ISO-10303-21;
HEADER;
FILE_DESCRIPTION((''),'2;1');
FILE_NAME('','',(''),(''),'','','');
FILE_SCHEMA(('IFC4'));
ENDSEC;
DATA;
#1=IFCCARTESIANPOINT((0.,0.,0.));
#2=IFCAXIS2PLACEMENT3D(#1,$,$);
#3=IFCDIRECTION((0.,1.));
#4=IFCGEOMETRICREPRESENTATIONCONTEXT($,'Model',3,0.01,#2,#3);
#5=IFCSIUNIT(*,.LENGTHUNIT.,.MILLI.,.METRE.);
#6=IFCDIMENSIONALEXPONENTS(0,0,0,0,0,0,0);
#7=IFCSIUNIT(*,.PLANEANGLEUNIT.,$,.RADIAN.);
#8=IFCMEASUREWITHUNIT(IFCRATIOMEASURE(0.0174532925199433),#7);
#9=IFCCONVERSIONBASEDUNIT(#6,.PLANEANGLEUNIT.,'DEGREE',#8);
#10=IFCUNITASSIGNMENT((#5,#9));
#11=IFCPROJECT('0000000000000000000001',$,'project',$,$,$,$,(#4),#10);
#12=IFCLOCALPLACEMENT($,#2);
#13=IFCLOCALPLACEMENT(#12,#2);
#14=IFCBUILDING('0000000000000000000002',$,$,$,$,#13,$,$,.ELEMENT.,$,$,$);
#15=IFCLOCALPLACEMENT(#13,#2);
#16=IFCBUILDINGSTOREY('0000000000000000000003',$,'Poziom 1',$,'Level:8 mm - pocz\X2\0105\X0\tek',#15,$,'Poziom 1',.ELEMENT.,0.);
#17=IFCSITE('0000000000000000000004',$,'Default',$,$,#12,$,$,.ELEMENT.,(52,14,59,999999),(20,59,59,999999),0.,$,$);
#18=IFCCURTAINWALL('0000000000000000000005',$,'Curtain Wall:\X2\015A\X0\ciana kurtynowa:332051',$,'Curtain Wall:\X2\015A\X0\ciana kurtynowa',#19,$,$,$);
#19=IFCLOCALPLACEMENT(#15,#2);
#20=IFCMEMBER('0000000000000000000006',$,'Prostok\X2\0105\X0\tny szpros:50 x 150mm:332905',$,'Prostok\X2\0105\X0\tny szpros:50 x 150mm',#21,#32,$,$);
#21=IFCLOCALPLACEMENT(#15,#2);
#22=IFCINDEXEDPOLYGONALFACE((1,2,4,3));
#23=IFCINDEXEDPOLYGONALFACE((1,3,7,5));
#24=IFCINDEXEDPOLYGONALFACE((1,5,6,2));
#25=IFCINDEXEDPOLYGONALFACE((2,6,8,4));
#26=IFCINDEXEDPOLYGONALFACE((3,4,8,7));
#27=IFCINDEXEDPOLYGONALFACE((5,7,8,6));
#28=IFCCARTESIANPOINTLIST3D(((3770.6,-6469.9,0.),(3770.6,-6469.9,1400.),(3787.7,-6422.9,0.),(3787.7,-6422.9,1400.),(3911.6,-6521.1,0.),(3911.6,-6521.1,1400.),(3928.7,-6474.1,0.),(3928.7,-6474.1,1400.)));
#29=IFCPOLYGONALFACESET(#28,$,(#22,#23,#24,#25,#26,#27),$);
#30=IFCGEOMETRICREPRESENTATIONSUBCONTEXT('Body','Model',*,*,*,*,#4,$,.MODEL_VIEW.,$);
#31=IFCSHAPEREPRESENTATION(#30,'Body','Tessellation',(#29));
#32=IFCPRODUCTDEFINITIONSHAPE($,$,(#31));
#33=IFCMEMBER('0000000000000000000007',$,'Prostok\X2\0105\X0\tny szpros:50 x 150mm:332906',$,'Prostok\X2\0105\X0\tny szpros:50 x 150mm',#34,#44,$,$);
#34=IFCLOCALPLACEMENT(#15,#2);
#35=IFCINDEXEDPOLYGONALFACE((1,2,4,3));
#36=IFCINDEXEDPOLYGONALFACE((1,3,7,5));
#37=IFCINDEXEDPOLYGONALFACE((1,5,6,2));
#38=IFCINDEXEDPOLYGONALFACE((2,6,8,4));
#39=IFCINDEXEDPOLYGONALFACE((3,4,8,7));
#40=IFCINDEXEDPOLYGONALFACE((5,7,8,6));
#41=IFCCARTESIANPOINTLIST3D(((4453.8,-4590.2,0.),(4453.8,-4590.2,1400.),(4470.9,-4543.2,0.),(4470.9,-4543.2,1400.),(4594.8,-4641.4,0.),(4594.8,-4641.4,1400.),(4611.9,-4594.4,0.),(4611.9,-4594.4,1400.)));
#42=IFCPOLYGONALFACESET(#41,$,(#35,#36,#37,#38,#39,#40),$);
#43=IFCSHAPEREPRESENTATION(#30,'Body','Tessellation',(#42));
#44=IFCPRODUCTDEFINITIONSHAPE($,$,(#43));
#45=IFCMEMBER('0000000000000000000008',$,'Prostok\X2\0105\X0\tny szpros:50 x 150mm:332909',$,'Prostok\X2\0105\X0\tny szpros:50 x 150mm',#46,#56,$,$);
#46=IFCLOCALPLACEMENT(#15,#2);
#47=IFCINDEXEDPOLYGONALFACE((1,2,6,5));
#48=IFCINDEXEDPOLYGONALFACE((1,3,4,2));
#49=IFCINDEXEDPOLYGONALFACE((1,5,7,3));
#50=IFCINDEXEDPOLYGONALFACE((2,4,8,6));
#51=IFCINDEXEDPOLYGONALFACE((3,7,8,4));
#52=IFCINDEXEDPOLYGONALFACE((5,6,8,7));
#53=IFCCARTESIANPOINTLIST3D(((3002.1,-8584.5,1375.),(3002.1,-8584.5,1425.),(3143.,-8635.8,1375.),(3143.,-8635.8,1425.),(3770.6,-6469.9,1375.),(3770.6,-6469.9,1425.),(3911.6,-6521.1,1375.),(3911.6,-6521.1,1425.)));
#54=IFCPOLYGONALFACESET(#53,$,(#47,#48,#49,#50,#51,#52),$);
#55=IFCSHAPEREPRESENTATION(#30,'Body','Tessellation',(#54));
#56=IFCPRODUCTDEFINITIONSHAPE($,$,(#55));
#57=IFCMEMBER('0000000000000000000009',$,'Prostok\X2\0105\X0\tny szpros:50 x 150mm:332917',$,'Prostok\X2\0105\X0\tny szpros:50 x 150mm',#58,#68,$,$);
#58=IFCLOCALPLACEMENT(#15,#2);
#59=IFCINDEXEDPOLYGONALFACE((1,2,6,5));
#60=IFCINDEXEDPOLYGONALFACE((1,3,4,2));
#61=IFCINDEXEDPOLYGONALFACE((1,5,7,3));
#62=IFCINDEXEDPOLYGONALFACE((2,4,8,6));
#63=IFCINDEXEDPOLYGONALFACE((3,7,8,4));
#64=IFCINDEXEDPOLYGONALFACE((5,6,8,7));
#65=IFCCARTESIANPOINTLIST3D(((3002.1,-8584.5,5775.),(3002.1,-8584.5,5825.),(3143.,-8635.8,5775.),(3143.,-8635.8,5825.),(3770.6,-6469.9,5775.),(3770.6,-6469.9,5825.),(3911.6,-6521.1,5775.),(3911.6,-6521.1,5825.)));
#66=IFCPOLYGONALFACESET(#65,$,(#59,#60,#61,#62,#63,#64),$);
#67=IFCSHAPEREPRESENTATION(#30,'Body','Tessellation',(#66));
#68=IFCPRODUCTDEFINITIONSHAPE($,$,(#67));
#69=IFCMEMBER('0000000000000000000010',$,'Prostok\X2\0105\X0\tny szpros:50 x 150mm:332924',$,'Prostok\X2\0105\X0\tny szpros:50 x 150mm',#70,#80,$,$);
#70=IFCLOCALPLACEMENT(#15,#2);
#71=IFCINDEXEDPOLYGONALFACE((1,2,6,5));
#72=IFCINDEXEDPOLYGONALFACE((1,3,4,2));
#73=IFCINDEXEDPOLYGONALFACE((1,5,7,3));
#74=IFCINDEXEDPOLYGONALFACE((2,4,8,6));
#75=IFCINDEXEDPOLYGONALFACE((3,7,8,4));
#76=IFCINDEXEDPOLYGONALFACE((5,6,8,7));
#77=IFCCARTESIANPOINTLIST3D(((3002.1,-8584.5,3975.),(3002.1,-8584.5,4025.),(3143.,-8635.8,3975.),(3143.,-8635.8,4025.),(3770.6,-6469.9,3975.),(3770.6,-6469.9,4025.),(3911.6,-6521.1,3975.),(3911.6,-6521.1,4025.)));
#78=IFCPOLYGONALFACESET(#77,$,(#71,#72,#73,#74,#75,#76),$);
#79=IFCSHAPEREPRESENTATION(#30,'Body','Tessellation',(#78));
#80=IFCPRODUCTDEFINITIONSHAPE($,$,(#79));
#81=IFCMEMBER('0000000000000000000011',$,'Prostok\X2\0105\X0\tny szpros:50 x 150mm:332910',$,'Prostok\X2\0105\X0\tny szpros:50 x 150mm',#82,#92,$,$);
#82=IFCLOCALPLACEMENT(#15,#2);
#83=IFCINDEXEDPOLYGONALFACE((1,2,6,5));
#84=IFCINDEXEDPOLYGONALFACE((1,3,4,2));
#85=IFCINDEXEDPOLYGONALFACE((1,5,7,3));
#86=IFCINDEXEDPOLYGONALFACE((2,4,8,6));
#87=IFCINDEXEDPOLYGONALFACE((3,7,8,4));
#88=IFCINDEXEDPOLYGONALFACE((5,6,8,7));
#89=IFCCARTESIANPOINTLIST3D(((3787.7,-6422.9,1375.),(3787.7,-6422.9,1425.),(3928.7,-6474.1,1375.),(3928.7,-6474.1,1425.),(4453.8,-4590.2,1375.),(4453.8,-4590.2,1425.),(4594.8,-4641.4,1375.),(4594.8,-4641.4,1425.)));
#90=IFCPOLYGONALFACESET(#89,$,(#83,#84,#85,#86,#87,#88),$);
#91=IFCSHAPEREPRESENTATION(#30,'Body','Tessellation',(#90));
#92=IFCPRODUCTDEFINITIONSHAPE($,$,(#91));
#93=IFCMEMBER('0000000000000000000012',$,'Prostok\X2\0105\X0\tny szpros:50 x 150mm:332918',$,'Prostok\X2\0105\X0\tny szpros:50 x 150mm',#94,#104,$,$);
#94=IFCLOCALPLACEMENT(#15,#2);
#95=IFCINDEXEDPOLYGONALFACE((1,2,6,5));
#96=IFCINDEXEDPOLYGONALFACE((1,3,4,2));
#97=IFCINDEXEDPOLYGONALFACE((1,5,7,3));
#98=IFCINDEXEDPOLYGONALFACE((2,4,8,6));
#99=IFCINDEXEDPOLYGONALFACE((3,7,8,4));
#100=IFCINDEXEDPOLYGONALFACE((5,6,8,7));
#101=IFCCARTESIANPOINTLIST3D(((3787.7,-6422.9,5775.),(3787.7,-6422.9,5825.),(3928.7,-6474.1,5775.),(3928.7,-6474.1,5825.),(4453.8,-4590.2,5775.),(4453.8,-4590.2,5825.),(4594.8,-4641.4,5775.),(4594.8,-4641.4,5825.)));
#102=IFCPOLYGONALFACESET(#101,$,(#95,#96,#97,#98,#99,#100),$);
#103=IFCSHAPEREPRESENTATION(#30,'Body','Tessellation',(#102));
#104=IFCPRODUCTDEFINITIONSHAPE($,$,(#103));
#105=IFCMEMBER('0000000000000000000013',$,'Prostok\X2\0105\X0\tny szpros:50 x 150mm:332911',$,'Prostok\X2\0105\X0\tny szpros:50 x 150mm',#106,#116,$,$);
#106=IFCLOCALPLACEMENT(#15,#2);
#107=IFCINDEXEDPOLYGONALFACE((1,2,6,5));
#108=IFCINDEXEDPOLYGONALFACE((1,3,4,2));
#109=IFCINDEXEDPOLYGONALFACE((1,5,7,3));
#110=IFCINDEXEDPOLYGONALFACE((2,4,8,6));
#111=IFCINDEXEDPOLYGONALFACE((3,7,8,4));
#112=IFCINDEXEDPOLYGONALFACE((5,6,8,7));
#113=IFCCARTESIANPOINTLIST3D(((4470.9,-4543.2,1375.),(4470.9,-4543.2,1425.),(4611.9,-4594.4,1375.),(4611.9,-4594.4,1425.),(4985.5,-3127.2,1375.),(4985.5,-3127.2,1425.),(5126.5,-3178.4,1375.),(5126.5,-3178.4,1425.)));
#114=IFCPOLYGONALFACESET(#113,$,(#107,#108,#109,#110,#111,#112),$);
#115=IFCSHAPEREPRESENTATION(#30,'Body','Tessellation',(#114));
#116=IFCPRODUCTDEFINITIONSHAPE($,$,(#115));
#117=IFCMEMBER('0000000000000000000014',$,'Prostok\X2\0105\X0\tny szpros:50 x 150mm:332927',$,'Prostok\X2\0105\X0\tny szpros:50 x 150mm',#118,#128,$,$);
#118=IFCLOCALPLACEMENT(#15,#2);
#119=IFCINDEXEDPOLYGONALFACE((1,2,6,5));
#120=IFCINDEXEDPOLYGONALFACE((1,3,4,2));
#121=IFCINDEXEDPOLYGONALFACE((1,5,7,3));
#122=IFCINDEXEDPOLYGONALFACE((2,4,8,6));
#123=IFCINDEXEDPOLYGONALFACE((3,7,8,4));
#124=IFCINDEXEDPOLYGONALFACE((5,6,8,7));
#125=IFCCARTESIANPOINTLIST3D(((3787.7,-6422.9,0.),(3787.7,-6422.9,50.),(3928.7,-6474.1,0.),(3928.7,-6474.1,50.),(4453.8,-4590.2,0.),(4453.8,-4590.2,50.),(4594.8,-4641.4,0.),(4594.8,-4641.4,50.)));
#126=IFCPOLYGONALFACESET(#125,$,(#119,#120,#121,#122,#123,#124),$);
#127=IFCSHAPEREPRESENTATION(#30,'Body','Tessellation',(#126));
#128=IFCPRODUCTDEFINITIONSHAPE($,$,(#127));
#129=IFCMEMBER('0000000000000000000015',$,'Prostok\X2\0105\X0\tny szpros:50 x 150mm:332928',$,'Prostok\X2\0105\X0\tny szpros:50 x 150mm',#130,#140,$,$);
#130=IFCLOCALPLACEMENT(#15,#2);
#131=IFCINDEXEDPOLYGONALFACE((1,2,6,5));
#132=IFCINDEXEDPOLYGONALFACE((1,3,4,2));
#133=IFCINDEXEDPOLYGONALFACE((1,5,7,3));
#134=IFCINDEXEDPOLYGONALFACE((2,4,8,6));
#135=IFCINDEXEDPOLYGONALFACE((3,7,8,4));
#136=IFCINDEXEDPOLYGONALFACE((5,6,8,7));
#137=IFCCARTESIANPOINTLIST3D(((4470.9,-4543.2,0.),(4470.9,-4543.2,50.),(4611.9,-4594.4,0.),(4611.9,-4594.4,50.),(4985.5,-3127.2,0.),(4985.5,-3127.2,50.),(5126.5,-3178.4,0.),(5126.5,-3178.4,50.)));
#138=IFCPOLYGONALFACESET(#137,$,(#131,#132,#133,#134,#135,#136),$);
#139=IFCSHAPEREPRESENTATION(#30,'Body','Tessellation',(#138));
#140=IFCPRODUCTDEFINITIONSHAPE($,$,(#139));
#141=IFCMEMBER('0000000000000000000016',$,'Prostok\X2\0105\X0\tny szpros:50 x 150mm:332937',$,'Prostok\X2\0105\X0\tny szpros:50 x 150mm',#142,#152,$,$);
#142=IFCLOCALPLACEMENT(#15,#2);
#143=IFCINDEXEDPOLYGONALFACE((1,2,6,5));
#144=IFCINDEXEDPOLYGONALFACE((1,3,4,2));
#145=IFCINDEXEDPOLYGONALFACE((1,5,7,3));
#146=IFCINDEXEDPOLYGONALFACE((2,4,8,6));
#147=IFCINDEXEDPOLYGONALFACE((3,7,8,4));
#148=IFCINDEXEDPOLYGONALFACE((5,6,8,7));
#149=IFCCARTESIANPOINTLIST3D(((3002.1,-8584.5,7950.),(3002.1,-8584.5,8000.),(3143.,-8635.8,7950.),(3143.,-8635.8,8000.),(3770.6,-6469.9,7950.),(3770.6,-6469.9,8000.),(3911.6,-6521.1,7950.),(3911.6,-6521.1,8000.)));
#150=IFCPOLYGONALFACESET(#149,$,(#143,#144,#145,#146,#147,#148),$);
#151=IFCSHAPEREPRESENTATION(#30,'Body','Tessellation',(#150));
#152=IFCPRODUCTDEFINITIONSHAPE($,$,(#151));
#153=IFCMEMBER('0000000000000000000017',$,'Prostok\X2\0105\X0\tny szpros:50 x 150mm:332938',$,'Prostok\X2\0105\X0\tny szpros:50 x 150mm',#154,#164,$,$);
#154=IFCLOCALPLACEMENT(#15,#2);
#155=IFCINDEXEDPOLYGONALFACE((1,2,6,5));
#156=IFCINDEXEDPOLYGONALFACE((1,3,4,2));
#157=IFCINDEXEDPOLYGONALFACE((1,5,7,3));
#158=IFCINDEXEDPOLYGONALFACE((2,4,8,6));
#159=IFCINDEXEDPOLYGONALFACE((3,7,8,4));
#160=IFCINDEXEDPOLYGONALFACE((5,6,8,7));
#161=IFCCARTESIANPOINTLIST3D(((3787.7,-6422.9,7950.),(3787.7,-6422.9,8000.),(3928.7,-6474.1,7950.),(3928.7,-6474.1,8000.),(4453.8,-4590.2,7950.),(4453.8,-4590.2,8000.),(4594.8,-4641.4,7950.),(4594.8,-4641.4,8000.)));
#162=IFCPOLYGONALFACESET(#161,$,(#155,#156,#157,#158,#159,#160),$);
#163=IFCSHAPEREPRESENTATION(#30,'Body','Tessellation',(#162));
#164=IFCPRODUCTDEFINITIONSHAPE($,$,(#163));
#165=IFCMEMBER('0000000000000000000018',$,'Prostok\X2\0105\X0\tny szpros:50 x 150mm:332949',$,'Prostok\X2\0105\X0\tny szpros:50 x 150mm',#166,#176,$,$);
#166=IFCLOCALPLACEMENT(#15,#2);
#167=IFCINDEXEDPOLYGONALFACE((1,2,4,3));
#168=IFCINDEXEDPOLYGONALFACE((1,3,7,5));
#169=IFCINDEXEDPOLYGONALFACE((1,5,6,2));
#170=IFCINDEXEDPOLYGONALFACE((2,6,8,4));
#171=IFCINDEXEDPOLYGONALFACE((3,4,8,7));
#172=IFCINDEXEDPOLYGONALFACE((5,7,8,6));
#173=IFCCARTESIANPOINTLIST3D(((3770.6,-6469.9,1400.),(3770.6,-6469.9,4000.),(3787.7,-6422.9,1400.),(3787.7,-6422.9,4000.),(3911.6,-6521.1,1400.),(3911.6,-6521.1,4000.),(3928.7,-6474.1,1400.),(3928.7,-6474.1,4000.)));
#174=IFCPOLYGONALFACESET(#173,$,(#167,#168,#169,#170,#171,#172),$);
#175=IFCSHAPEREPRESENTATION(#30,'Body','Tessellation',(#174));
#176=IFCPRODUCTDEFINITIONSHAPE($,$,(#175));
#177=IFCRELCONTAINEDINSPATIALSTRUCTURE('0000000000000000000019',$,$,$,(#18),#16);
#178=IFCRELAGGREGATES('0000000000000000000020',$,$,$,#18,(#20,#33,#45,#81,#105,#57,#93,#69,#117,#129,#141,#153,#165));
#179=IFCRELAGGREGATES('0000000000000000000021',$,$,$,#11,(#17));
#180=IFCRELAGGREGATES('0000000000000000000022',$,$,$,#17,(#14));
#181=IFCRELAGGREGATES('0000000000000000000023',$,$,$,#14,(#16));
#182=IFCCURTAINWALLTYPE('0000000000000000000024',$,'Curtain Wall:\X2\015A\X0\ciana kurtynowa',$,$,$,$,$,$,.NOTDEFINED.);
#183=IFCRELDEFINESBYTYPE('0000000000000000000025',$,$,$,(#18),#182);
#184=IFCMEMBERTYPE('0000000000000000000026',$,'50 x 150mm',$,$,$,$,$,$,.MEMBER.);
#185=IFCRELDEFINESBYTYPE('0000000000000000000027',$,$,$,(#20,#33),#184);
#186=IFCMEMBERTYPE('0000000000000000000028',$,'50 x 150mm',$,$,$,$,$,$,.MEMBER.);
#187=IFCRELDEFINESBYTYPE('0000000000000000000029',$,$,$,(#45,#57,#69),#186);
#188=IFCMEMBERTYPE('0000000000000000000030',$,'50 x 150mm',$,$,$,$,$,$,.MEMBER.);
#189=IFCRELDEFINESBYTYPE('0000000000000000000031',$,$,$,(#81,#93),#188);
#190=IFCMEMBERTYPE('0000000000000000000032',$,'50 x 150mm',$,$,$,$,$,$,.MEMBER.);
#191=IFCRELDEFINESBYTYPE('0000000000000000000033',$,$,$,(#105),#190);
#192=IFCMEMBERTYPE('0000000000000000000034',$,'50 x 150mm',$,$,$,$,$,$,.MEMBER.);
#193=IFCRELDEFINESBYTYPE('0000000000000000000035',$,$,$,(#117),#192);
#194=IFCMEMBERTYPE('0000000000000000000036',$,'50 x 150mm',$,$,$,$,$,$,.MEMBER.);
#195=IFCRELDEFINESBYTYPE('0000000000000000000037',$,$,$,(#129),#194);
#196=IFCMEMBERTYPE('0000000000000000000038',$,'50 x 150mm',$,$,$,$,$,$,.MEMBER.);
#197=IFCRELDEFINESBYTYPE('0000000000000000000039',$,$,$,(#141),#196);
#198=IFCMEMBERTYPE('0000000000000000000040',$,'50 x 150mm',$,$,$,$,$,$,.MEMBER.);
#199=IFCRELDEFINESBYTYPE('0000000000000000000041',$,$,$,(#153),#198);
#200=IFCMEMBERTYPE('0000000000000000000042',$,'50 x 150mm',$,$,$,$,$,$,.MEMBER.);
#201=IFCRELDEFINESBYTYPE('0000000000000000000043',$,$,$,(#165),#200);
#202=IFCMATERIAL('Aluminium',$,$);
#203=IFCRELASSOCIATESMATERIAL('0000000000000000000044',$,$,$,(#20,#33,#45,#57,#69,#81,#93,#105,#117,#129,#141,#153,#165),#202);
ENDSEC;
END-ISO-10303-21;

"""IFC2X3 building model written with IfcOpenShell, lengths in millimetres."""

from ifc_helpers import new_model, entity, si_unit, converted_unit, direction, frame, origin, origin_2d_with_axis, place, context, subcontext, project, spatial, rectangle, extrude, source, transform, mapped, material, type_object, type_shapes, element, aggregate, save


model = new_model("IFC2X3")

# Units and contexts
model_context = context("Model", 3, precision=0.01, world=origin(), true_north=direction((0.0, 1.0)))
body_context = subcontext(model_context, "Body", "Model", "MODEL_VIEW")
ifc_project = project(units=[si_unit("LENGTHUNIT", "METRE", prefix="MILLI"), converted_unit("PLANEANGLEUNIT", "DEGREE", entity("IfcRatioMeasure", 0.0174532925199433), si_unit("PLANEANGLEUNIT", "RADIAN"), dimensions=[0, 0, 0, 0, 0, 0, 0])], contexts=[model_context])

# Site, building, storey
site_placement = place(None, origin())
site = spatial("IfcSite", under=ifc_project, at=site_placement, Name="Default", CompositionType="ELEMENT", RefLatitude=(52, 14, 59, 999999), RefLongitude=(20, 59, 59, 999999), RefElevation=0.0)
building_placement = place(site_placement, origin())
building = spatial("IfcBuilding", under=site, at=building_placement, CompositionType="ELEMENT")
storey_placement = place(building_placement, origin())
storey = spatial("IfcBuildingStorey", under=building, at=storey_placement, Name="Poziom 1", ObjectType="Level:8 mm - początek", LongName="Poziom 1", CompositionType="ELEMENT", Elevation=0.0)

# Curtain wall, members
curtain_wall_type = type_object("IfcCurtainWallType", Name="Curtain Wall:Ściana kurtynowa", PredefinedType="NOTDEFINED")
curtain_wall_placement = place(storey_placement, origin())
curtain_wall = element("IfcCurtainWall", 1, at=curtain_wall_placement, inside=storey, type_object=curtain_wall_type, Name="Curtain Wall:Ściana kurtynowa:332051", ObjectType="Curtain Wall:Ściana kurtynowa")
ifc_material_1 = material(Name="Aluminium")
member_type_1 = type_object("IfcMemberType", Name="50 x 150mm", PredefinedType="MEMBER")
shared_shape_1 = source(origin(), body_context, "Body", "SweptSolid", [
    extrude(rectangle(XDim=150.0, YDim=50.0, at=origin_2d_with_axis()), frame((0.0, 0.0, -1400.0), z_axis=(0.0, 0.0, 1.0), x_axis=(0.0, -1.0, 0.0)), (0.0, 0.0, 1.0), 1400.0),
])
type_shapes(member_type_1, [shared_shape_1])
member_1_placement = place(storey_placement, frame((3849.7, -6472.0, 0.0), z_axis=(0.0, 0.0, -1.0), x_axis=(0.341586, 0.939851, 0.0)))
member_1 = element("IfcMember", 2, at=member_1_placement, type_object=member_type_1, material=ifc_material_1, Name="Prostokątny szpros:50 x 150mm:332905", ObjectType="Prostokątny szpros:50 x 150mm", context=body_context, shape_type="MappedRepresentation", body=[
    mapped(shared_shape_1, transform((0.0, 0.0, 0.0), scale=1.0)),
])
member_2_placement = place(storey_placement, frame((4532.8, -4592.3, 0.0), z_axis=(0.0, 0.0, -1.0), x_axis=(0.341586, 0.939851, 0.0)))
member_2 = element("IfcMember", 3, at=member_2_placement, type_object=member_type_1, material=ifc_material_1, Name="Prostokątny szpros:50 x 150mm:332906", ObjectType="Prostokątny szpros:50 x 150mm", context=body_context, shape_type="MappedRepresentation", body=[
    mapped(shared_shape_1, transform((0.0, 0.0, 0.0), scale=1.0)),
])
member_type_2 = type_object("IfcMemberType", Name="50 x 150mm", PredefinedType="MEMBER")
shared_shape_2 = source(origin(), body_context, "Body", "SweptSolid", [
    extrude(rectangle(XDim=150.0, YDim=50.0, at=origin_2d_with_axis()), frame((0.0, 0.0, -2250.0), z_axis=(0.0, 0.0, 1.0), x_axis=(0.0, -1.0, 0.0)), (0.0, 0.0, 1.0), 2250.0),
])
type_shapes(member_type_2, [shared_shape_2])
member_3_placement = place(storey_placement, frame((3841.1, -6495.5, 1400.0), z_axis=(0.341586, 0.939851, 0.0), x_axis=(0.0, 0.0, 1.0)))
member_3 = element("IfcMember", 4, at=member_3_placement, type_object=member_type_2, material=ifc_material_1, Name="Prostokątny szpros:50 x 150mm:332909", ObjectType="Prostokątny szpros:50 x 150mm", context=body_context, shape_type="MappedRepresentation", body=[
    mapped(shared_shape_2, transform((0.0, 0.0, 0.0), scale=1.0)),
])
member_4_placement = place(storey_placement, frame((3841.1, -6495.5, 5800.0), z_axis=(0.341586, 0.939851, 0.0), x_axis=(0.0, 0.0, 1.0)))
member_4 = element("IfcMember", 5, at=member_4_placement, type_object=member_type_2, material=ifc_material_1, Name="Prostokątny szpros:50 x 150mm:332917", ObjectType="Prostokątny szpros:50 x 150mm", context=body_context, shape_type="MappedRepresentation", body=[
    mapped(shared_shape_2, transform((0.0, 0.0, 0.0), scale=1.0)),
])
member_5_placement = place(storey_placement, frame((3841.1, -6495.5, 4000.0), z_axis=(0.341586, 0.939851, 0.0), x_axis=(0.0, 0.0, 1.0)))
member_5 = element("IfcMember", 6, at=member_5_placement, type_object=member_type_2, material=ifc_material_1, Name="Prostokątny szpros:50 x 150mm:332924", ObjectType="Prostokątny szpros:50 x 150mm", context=body_context, shape_type="MappedRepresentation", body=[
    mapped(shared_shape_2, transform((0.0, 0.0, 0.0), scale=1.0)),
])
member_type_3 = type_object("IfcMemberType", Name="50 x 150mm", PredefinedType="MEMBER")
shared_shape_3 = source(origin(), body_context, "Body", "SweptSolid", [
    extrude(rectangle(XDim=150.0, YDim=50.0, at=origin_2d_with_axis()), frame((0.0, 0.0, -1950.0), z_axis=(0.0, 0.0, 1.0), x_axis=(0.0, -1.0, 0.0)), (0.0, 0.0, 1.0), 1950.0),
])
type_shapes(member_type_3, [shared_shape_3])
member_6_placement = place(storey_placement, frame((4524.3, -4615.8, 1400.0), z_axis=(0.341586, 0.939851, 0.0), x_axis=(0.0, 0.0, 1.0)))
member_6 = element("IfcMember", 7, at=member_6_placement, type_object=member_type_3, material=ifc_material_1, Name="Prostokątny szpros:50 x 150mm:332910", ObjectType="Prostokątny szpros:50 x 150mm", context=body_context, shape_type="MappedRepresentation", body=[
    mapped(shared_shape_3, transform((0.0, 0.0, 0.0), scale=1.0)),
])
member_7_placement = place(storey_placement, frame((4524.3, -4615.8, 5800.0), z_axis=(0.341586, 0.939851, 0.0), x_axis=(0.0, 0.0, 1.0)))
member_7 = element("IfcMember", 8, at=member_7_placement, type_object=member_type_3, material=ifc_material_1, Name="Prostokątny szpros:50 x 150mm:332918", ObjectType="Prostokątny szpros:50 x 150mm", context=body_context, shape_type="MappedRepresentation", body=[
    mapped(shared_shape_3, transform((0.0, 0.0, 0.0), scale=1.0)),
])
member_type_4 = type_object("IfcMemberType", Name="50 x 150mm", PredefinedType="MEMBER")
shared_shape_4 = source(origin(), body_context, "Body", "SweptSolid", [
    extrude(rectangle(XDim=150.0, YDim=50.0, at=origin_2d_with_axis()), frame((0.0, 0.0, -1506.6), z_axis=(0.0, 0.0, 1.0), x_axis=(0.0, -1.0, 0.0)), (0.0, 0.0, 1.0), 1506.6),
])
type_shapes(member_type_4, [shared_shape_4])
member_8_placement = place(storey_placement, frame((5056.0, -3152.8, 1400.0), z_axis=(0.341586, 0.939851, 0.0), x_axis=(0.0, 0.0, 1.0)))
member_8 = element("IfcMember", 9, at=member_8_placement, type_object=member_type_4, material=ifc_material_1, Name="Prostokątny szpros:50 x 150mm:332911", ObjectType="Prostokątny szpros:50 x 150mm", context=body_context, shape_type="MappedRepresentation", body=[
    mapped(shared_shape_4, transform((0.0, 0.0, 0.0), scale=1.0)),
])
member_type_5 = type_object("IfcMemberType", Name="50 x 150mm", PredefinedType="MEMBER")
shared_shape_5 = source(origin(), body_context, "Body", "SweptSolid", [
    extrude(rectangle(XDim=150.0, YDim=50.0, at=origin_2d_with_axis()), frame((-25.0, 0.0, -1950.0), z_axis=(0.0, 0.0, 1.0), x_axis=(0.0, -1.0, 0.0)), (0.0, 0.0, 1.0), 1950.0),
])
type_shapes(member_type_5, [shared_shape_5])
member_9_placement = place(storey_placement, frame((3858.2, -6448.5, 0.0), z_axis=(-0.341586, -0.939851, 0.0), x_axis=(0.0, 0.0, -1.0)))
member_9 = element("IfcMember", 10, at=member_9_placement, type_object=member_type_5, material=ifc_material_1, Name="Prostokątny szpros:50 x 150mm:332927", ObjectType="Prostokątny szpros:50 x 150mm", context=body_context, shape_type="MappedRepresentation", body=[
    mapped(shared_shape_5, transform((0.0, 0.0, 0.0), scale=1.0)),
])
member_type_6 = type_object("IfcMemberType", Name="50 x 150mm", PredefinedType="MEMBER")
shared_shape_6 = source(origin(), body_context, "Body", "SweptSolid", [
    extrude(rectangle(XDim=150.0, YDim=50.0, at=origin_2d_with_axis()), frame((-25.0, 0.0, -1506.6), z_axis=(0.0, 0.0, 1.0), x_axis=(0.0, -1.0, 0.0)), (0.0, 0.0, 1.0), 1506.6),
])
type_shapes(member_type_6, [shared_shape_6])
member_10_placement = place(storey_placement, frame((4541.4, -4568.8, 0.0), z_axis=(-0.341586, -0.939851, 0.0), x_axis=(0.0, 0.0, -1.0)))
member_10 = element("IfcMember", 11, at=member_10_placement, type_object=member_type_6, material=ifc_material_1, Name="Prostokątny szpros:50 x 150mm:332928", ObjectType="Prostokątny szpros:50 x 150mm", context=body_context, shape_type="MappedRepresentation", body=[
    mapped(shared_shape_6, transform((0.0, 0.0, 0.0), scale=1.0)),
])
member_type_7 = type_object("IfcMemberType", Name="50 x 150mm", PredefinedType="MEMBER")
shared_shape_7 = source(origin(), body_context, "Body", "SweptSolid", [
    extrude(rectangle(XDim=150.0, YDim=50.0, at=origin_2d_with_axis()), frame((-25.0, 0.0, -2250.0), z_axis=(0.0, 0.0, 1.0), x_axis=(0.0, -1.0, 0.0)), (0.0, 0.0, 1.0), 2250.0),
])
type_shapes(member_type_7, [shared_shape_7])
member_11_placement = place(storey_placement, frame((3841.1, -6495.5, 8000.0), z_axis=(0.341586, 0.939851, 0.0), x_axis=(0.0, 0.0, 1.0)))
member_11 = element("IfcMember", 12, at=member_11_placement, type_object=member_type_7, material=ifc_material_1, Name="Prostokątny szpros:50 x 150mm:332937", ObjectType="Prostokątny szpros:50 x 150mm", context=body_context, shape_type="MappedRepresentation", body=[
    mapped(shared_shape_7, transform((0.0, 0.0, 0.0), scale=1.0)),
])
member_type_8 = type_object("IfcMemberType", Name="50 x 150mm", PredefinedType="MEMBER")
shared_shape_8 = source(origin(), body_context, "Body", "SweptSolid", [
    extrude(rectangle(XDim=150.0, YDim=50.0, at=origin_2d_with_axis()), frame((-25.0, 0.0, -1950.0), z_axis=(0.0, 0.0, 1.0), x_axis=(0.0, -1.0, 0.0)), (0.0, 0.0, 1.0), 1950.0),
])
type_shapes(member_type_8, [shared_shape_8])
member_12_placement = place(storey_placement, frame((4524.3, -4615.8, 8000.0), z_axis=(0.341586, 0.939851, 0.0), x_axis=(0.0, 0.0, 1.0)))
member_12 = element("IfcMember", 13, at=member_12_placement, type_object=member_type_8, material=ifc_material_1, Name="Prostokątny szpros:50 x 150mm:332938", ObjectType="Prostokątny szpros:50 x 150mm", context=body_context, shape_type="MappedRepresentation", body=[
    mapped(shared_shape_8, transform((0.0, 0.0, 0.0), scale=1.0)),
])
member_type_9 = type_object("IfcMemberType", Name="50 x 150mm", PredefinedType="MEMBER")
shared_shape_9 = source(origin(), body_context, "Body", "SweptSolid", [
    extrude(rectangle(XDim=150.0, YDim=50.0, at=origin_2d_with_axis()), frame((0.0, 0.0, -2600.0), z_axis=(0.0, 0.0, 1.0), x_axis=(0.0, -1.0, 0.0)), (0.0, 0.0, 1.0), 2600.0),
])
type_shapes(member_type_9, [shared_shape_9])
member_13_placement = place(storey_placement, frame((3849.7, -6472.0, 1400.0), z_axis=(0.0, 0.0, -1.0), x_axis=(0.341586, 0.939851, 0.0)))
member_13 = element("IfcMember", 14, at=member_13_placement, type_object=member_type_9, material=ifc_material_1, Name="Prostokątny szpros:50 x 150mm:332949", ObjectType="Prostokątny szpros:50 x 150mm", context=body_context, shape_type="MappedRepresentation", body=[
    mapped(shared_shape_9, transform((0.0, 0.0, 0.0), scale=1.0)),
])
aggregate(curtain_wall, [member_1, member_2, member_3, member_6, member_8, member_4, member_7, member_5, member_9, member_10, member_11, member_12, member_13])

save(model, "model.ifc")
